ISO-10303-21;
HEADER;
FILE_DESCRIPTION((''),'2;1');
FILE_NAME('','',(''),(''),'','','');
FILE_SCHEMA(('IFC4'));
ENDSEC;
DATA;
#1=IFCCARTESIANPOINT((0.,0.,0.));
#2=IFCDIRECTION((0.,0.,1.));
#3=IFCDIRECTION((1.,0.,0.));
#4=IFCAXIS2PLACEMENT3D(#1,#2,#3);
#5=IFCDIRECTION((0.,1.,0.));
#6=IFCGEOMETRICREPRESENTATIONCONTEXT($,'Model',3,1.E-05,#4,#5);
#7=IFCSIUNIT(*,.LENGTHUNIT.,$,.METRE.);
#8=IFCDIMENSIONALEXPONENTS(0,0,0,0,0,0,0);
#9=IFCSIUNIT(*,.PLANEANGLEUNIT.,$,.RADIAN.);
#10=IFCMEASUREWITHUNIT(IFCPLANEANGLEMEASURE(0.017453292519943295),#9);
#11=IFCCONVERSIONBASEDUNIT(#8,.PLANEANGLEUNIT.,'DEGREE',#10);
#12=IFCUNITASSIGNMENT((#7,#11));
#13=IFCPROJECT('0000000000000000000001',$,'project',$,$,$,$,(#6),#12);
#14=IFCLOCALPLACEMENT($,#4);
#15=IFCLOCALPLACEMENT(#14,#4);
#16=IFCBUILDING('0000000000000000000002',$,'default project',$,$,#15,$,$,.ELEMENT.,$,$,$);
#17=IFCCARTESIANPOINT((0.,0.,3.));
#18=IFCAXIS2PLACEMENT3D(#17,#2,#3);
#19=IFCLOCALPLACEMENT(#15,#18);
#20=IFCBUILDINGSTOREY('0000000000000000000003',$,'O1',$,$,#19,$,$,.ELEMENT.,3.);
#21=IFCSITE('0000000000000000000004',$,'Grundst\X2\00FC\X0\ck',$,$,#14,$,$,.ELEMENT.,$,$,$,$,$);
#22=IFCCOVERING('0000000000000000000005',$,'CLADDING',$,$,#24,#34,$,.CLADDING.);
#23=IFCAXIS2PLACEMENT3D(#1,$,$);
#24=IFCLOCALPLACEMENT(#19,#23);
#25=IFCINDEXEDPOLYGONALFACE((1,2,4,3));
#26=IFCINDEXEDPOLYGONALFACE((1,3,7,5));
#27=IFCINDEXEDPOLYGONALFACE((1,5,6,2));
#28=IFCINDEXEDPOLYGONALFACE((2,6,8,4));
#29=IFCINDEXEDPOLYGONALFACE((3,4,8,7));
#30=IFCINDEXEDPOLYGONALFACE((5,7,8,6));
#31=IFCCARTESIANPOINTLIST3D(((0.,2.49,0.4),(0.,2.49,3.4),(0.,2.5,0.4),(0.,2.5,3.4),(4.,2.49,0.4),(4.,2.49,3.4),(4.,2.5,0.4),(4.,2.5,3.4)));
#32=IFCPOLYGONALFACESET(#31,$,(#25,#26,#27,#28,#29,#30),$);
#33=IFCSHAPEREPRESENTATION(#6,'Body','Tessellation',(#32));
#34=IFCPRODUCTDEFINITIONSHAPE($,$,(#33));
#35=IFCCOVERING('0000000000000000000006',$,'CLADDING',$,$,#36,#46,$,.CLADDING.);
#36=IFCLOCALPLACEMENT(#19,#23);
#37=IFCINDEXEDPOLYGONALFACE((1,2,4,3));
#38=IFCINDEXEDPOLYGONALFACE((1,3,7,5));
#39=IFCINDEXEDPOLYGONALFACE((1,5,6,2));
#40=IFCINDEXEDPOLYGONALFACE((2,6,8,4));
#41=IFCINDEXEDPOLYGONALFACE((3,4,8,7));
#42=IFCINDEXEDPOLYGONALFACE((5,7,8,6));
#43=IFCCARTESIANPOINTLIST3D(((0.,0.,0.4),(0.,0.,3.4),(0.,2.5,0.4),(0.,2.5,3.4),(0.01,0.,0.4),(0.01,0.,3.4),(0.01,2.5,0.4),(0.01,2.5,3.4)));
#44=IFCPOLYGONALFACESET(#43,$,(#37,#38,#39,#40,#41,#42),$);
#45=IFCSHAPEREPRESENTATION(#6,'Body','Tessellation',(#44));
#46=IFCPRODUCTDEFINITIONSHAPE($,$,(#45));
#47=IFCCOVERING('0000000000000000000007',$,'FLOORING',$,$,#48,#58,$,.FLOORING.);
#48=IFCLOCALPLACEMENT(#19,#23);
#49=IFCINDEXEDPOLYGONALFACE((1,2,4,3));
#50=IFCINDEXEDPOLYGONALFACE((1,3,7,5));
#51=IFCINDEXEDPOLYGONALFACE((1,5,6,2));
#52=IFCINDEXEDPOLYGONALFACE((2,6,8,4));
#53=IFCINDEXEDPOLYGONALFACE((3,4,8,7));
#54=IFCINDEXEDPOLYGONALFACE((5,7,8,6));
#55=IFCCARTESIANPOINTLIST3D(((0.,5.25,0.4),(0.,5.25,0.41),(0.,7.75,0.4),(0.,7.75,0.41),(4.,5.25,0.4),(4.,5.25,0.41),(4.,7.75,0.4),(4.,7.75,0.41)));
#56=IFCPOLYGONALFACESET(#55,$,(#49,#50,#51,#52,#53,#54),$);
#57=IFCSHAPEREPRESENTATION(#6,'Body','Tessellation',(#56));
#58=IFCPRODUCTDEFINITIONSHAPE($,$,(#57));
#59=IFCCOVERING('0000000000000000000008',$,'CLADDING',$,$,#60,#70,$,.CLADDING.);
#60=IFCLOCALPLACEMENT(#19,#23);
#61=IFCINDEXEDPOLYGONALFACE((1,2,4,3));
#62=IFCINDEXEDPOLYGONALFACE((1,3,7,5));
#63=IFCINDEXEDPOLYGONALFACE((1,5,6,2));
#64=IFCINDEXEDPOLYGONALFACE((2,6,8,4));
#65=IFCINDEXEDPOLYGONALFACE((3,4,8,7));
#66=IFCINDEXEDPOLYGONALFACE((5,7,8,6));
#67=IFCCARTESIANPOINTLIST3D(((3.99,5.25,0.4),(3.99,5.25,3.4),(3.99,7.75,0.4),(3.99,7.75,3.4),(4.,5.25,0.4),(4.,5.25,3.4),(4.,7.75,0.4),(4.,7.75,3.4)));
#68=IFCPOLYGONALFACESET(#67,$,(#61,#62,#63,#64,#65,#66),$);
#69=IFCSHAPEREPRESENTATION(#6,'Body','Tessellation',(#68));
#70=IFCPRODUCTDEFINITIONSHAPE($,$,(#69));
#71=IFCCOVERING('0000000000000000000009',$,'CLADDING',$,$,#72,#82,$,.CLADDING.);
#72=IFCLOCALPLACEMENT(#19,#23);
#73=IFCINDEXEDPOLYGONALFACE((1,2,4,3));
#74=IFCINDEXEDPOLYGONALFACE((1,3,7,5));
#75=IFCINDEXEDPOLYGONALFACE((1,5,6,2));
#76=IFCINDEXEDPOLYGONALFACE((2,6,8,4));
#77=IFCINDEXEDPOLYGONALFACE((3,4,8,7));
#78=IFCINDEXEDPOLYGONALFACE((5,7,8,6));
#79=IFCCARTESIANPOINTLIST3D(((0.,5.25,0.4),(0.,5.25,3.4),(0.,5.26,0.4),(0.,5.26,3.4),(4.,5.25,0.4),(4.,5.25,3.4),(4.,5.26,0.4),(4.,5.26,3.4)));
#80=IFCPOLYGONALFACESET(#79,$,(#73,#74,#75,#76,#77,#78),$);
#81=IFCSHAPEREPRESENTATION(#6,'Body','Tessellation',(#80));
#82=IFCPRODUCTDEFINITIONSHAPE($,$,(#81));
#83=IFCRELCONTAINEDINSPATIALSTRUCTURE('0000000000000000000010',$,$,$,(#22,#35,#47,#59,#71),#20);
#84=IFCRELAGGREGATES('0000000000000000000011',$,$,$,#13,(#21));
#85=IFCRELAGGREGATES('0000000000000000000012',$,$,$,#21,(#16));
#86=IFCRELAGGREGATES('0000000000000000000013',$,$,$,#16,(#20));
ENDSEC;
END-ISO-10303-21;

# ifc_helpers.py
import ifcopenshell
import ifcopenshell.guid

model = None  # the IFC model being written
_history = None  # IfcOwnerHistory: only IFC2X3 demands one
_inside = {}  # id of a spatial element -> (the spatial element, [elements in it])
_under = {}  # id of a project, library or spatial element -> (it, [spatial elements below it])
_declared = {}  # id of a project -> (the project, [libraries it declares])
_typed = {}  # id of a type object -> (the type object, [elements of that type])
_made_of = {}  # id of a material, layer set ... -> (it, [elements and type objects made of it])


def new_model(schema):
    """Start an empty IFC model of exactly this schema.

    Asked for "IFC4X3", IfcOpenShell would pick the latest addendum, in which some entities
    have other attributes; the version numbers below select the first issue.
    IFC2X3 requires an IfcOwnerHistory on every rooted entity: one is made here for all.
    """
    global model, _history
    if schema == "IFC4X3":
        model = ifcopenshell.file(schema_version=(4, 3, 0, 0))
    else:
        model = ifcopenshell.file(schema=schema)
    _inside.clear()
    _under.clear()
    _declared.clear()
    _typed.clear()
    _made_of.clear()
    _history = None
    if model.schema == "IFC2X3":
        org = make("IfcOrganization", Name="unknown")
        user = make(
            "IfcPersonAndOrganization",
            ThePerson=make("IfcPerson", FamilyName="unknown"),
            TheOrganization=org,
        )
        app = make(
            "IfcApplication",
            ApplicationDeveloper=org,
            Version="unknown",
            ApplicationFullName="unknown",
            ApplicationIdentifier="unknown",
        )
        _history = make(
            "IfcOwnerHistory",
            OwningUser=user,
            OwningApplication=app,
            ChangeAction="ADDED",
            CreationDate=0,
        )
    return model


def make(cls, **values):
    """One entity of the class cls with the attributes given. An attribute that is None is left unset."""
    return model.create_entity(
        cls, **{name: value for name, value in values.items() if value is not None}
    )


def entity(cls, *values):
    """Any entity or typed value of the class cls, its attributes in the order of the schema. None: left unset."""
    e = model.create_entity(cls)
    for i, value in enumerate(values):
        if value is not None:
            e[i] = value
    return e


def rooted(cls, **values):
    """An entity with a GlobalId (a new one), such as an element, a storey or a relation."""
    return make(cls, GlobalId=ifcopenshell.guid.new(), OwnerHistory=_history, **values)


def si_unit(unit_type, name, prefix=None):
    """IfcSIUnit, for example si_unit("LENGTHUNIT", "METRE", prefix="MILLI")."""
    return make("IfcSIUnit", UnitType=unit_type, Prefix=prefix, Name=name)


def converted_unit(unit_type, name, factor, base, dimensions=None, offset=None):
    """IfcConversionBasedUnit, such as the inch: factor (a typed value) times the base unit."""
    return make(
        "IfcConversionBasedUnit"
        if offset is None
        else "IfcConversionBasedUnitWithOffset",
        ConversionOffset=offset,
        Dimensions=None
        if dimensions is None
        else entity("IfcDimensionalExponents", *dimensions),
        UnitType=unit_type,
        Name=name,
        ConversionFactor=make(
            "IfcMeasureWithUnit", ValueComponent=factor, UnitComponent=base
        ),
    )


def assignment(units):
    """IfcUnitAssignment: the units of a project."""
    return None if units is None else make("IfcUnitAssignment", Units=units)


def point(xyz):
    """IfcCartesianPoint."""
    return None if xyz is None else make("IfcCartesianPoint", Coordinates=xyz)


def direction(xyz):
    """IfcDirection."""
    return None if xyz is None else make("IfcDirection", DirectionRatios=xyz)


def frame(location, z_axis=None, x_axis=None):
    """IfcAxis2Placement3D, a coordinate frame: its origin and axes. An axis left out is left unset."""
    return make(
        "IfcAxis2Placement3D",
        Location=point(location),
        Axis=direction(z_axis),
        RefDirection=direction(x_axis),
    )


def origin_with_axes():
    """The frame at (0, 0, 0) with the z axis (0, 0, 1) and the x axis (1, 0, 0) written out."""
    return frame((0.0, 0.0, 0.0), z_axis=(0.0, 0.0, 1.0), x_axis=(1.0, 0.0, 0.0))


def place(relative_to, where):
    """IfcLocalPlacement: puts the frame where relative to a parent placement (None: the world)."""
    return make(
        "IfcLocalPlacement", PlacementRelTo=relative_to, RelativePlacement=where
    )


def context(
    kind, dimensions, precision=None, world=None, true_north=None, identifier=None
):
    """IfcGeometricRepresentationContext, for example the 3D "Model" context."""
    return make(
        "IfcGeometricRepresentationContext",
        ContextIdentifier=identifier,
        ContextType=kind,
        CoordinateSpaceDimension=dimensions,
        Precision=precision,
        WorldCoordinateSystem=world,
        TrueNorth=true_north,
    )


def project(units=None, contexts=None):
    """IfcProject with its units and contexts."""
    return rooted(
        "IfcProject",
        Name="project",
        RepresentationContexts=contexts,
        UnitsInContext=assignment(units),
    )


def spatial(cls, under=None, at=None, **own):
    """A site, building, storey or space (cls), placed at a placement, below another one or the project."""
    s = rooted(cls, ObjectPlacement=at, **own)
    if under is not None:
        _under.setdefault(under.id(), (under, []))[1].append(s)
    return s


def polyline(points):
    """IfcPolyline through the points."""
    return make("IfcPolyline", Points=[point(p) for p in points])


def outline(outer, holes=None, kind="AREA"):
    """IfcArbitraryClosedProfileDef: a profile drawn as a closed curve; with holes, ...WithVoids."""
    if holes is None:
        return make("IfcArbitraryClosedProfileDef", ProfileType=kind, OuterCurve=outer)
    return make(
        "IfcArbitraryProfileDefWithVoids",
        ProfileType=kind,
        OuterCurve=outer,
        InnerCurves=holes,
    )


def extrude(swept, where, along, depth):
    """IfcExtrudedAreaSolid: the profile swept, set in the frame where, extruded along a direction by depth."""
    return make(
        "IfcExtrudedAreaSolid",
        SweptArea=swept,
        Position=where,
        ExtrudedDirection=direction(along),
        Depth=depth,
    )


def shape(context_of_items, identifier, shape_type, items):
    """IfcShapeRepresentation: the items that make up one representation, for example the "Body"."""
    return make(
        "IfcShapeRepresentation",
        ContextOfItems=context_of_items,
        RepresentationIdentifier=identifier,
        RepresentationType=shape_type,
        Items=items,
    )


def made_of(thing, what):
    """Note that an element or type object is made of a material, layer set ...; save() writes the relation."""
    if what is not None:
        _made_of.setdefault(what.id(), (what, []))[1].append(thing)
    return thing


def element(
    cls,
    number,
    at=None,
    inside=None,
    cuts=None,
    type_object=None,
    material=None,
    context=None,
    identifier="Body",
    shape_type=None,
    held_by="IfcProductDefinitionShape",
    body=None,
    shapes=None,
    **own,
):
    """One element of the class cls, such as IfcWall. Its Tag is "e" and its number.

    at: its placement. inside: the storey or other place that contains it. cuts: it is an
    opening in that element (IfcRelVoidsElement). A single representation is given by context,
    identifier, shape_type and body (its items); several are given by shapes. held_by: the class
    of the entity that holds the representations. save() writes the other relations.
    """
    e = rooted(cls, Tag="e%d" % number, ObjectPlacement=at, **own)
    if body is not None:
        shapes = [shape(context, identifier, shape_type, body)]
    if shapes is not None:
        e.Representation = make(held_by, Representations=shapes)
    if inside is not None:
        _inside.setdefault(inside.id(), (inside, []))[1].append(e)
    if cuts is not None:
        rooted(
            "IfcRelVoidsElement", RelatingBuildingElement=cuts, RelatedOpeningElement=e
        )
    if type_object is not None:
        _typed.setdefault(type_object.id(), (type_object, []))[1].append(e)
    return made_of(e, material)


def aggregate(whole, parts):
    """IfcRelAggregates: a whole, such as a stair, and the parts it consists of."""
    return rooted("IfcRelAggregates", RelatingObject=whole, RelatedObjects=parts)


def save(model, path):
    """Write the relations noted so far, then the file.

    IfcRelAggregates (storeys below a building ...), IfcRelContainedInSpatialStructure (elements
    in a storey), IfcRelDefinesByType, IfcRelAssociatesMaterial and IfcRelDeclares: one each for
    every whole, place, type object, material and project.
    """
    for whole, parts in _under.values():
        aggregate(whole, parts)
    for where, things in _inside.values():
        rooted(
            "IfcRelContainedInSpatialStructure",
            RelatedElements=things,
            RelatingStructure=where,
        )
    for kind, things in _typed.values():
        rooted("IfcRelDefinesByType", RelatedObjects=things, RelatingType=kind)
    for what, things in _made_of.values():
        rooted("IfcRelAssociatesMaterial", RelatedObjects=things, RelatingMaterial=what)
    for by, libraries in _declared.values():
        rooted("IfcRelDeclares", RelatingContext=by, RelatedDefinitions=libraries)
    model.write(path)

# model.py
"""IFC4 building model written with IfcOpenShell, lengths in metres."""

from ifc_helpers import new_model, entity, si_unit, converted_unit, direction, frame, origin_with_axes, place, context, project, spatial, polyline, outline, extrude, element, save


model = new_model("IFC4")

# Units and contexts
model_context = context("Model", 3, precision=1e-05, world=origin_with_axes(), true_north=direction((0.0, 1.0, 0.0)))
ifc_project = project(units=[si_unit("LENGTHUNIT", "METRE"), converted_unit("PLANEANGLEUNIT", "DEGREE", entity("IfcPlaneAngleMeasure", 0.017453292519943295), si_unit("PLANEANGLEUNIT", "RADIAN"), dimensions=[0, 0, 0, 0, 0, 0, 0])], contexts=[model_context])

# Site, building, storey
site_placement = place(None, origin_with_axes())
site = spatial("IfcSite", under=ifc_project, at=site_placement, Name="Grundstück", CompositionType="ELEMENT")
building_placement = place(site_placement, origin_with_axes())
building = spatial("IfcBuilding", under=site, at=building_placement, Name="default project", CompositionType="ELEMENT")
placement_1 = place(building_placement, frame((0.0, 0.0, 3.0), z_axis=(0.0, 0.0, 1.0), x_axis=(1.0, 0.0, 0.0)))
storey = spatial("IfcBuildingStorey", under=building, at=placement_1, Name="O1", CompositionType="ELEMENT", Elevation=3.0)

# Coverings
element("IfcCovering", 1, at=placement_1, inside=storey, Name="CLADDING", PredefinedType="CLADDING", context=model_context, shape_type="SweptSolid", body=[
    extrude(outline(polyline([(0.0, 2.49), (4.0, 2.49), (4.0, 2.5), (0.0, 2.5), (0.0, 2.49)])), frame((0.0, 0.0, 0.4), z_axis=(0.0, 0.0, 1.0), x_axis=(1.0, 0.0, 0.0)), (0.0, 0.0, 1.0), 3.0),
])
element("IfcCovering", 2, at=placement_1, inside=storey, Name="CLADDING", PredefinedType="CLADDING", context=model_context, shape_type="SweptSolid", body=[
    extrude(outline(polyline([(0.01, 0.0), (0.01, 2.5), (0.0, 2.5), (0.0, 0.0), (0.01, 0.0)])), frame((0.0, 0.0, 0.4), z_axis=(0.0, 0.0, 1.0), x_axis=(1.0, 0.0, 0.0)), (0.0, 0.0, 1.0), 3.0),
])
element("IfcCovering", 3, at=placement_1, inside=storey, Name="FLOORING", PredefinedType="FLOORING", context=model_context, shape_type="SweptSolid", body=[
    extrude(outline(polyline([(4.0, 7.75), (0.0, 7.75), (0.0, 5.25), (4.0, 5.25), (4.0, 7.75)])), frame((0.0, 0.0, 0.4), z_axis=(0.0, 0.0, 1.0), x_axis=(1.0, 0.0, 0.0)), (0.0, 0.0, 1.0), 0.01),
])
element("IfcCovering", 4, at=placement_1, inside=storey, Name="CLADDING", PredefinedType="CLADDING", context=model_context, shape_type="SweptSolid", body=[
    extrude(outline(polyline([(3.99, 7.75), (3.99, 5.25), (4.0, 5.25), (4.0, 7.75), (3.99, 7.75)])), frame((0.0, 0.0, 0.4), z_axis=(0.0, 0.0, 1.0), x_axis=(1.0, 0.0, 0.0)), (0.0, 0.0, 1.0), 3.0),
])
element("IfcCovering", 5, at=placement_1, inside=storey, Name="CLADDING", PredefinedType="CLADDING", context=model_context, shape_type="SweptSolid", body=[
    extrude(outline(polyline([(4.0, 5.26), (0.0, 5.26), (0.0, 5.25), (4.0, 5.25), (4.0, 5.26)])), frame((0.0, 0.0, 0.4), z_axis=(0.0, 0.0, 1.0), x_axis=(1.0, 0.0, 0.0)), (0.0, 0.0, 1.0), 3.0),
])

save(model, "model.ifc")
